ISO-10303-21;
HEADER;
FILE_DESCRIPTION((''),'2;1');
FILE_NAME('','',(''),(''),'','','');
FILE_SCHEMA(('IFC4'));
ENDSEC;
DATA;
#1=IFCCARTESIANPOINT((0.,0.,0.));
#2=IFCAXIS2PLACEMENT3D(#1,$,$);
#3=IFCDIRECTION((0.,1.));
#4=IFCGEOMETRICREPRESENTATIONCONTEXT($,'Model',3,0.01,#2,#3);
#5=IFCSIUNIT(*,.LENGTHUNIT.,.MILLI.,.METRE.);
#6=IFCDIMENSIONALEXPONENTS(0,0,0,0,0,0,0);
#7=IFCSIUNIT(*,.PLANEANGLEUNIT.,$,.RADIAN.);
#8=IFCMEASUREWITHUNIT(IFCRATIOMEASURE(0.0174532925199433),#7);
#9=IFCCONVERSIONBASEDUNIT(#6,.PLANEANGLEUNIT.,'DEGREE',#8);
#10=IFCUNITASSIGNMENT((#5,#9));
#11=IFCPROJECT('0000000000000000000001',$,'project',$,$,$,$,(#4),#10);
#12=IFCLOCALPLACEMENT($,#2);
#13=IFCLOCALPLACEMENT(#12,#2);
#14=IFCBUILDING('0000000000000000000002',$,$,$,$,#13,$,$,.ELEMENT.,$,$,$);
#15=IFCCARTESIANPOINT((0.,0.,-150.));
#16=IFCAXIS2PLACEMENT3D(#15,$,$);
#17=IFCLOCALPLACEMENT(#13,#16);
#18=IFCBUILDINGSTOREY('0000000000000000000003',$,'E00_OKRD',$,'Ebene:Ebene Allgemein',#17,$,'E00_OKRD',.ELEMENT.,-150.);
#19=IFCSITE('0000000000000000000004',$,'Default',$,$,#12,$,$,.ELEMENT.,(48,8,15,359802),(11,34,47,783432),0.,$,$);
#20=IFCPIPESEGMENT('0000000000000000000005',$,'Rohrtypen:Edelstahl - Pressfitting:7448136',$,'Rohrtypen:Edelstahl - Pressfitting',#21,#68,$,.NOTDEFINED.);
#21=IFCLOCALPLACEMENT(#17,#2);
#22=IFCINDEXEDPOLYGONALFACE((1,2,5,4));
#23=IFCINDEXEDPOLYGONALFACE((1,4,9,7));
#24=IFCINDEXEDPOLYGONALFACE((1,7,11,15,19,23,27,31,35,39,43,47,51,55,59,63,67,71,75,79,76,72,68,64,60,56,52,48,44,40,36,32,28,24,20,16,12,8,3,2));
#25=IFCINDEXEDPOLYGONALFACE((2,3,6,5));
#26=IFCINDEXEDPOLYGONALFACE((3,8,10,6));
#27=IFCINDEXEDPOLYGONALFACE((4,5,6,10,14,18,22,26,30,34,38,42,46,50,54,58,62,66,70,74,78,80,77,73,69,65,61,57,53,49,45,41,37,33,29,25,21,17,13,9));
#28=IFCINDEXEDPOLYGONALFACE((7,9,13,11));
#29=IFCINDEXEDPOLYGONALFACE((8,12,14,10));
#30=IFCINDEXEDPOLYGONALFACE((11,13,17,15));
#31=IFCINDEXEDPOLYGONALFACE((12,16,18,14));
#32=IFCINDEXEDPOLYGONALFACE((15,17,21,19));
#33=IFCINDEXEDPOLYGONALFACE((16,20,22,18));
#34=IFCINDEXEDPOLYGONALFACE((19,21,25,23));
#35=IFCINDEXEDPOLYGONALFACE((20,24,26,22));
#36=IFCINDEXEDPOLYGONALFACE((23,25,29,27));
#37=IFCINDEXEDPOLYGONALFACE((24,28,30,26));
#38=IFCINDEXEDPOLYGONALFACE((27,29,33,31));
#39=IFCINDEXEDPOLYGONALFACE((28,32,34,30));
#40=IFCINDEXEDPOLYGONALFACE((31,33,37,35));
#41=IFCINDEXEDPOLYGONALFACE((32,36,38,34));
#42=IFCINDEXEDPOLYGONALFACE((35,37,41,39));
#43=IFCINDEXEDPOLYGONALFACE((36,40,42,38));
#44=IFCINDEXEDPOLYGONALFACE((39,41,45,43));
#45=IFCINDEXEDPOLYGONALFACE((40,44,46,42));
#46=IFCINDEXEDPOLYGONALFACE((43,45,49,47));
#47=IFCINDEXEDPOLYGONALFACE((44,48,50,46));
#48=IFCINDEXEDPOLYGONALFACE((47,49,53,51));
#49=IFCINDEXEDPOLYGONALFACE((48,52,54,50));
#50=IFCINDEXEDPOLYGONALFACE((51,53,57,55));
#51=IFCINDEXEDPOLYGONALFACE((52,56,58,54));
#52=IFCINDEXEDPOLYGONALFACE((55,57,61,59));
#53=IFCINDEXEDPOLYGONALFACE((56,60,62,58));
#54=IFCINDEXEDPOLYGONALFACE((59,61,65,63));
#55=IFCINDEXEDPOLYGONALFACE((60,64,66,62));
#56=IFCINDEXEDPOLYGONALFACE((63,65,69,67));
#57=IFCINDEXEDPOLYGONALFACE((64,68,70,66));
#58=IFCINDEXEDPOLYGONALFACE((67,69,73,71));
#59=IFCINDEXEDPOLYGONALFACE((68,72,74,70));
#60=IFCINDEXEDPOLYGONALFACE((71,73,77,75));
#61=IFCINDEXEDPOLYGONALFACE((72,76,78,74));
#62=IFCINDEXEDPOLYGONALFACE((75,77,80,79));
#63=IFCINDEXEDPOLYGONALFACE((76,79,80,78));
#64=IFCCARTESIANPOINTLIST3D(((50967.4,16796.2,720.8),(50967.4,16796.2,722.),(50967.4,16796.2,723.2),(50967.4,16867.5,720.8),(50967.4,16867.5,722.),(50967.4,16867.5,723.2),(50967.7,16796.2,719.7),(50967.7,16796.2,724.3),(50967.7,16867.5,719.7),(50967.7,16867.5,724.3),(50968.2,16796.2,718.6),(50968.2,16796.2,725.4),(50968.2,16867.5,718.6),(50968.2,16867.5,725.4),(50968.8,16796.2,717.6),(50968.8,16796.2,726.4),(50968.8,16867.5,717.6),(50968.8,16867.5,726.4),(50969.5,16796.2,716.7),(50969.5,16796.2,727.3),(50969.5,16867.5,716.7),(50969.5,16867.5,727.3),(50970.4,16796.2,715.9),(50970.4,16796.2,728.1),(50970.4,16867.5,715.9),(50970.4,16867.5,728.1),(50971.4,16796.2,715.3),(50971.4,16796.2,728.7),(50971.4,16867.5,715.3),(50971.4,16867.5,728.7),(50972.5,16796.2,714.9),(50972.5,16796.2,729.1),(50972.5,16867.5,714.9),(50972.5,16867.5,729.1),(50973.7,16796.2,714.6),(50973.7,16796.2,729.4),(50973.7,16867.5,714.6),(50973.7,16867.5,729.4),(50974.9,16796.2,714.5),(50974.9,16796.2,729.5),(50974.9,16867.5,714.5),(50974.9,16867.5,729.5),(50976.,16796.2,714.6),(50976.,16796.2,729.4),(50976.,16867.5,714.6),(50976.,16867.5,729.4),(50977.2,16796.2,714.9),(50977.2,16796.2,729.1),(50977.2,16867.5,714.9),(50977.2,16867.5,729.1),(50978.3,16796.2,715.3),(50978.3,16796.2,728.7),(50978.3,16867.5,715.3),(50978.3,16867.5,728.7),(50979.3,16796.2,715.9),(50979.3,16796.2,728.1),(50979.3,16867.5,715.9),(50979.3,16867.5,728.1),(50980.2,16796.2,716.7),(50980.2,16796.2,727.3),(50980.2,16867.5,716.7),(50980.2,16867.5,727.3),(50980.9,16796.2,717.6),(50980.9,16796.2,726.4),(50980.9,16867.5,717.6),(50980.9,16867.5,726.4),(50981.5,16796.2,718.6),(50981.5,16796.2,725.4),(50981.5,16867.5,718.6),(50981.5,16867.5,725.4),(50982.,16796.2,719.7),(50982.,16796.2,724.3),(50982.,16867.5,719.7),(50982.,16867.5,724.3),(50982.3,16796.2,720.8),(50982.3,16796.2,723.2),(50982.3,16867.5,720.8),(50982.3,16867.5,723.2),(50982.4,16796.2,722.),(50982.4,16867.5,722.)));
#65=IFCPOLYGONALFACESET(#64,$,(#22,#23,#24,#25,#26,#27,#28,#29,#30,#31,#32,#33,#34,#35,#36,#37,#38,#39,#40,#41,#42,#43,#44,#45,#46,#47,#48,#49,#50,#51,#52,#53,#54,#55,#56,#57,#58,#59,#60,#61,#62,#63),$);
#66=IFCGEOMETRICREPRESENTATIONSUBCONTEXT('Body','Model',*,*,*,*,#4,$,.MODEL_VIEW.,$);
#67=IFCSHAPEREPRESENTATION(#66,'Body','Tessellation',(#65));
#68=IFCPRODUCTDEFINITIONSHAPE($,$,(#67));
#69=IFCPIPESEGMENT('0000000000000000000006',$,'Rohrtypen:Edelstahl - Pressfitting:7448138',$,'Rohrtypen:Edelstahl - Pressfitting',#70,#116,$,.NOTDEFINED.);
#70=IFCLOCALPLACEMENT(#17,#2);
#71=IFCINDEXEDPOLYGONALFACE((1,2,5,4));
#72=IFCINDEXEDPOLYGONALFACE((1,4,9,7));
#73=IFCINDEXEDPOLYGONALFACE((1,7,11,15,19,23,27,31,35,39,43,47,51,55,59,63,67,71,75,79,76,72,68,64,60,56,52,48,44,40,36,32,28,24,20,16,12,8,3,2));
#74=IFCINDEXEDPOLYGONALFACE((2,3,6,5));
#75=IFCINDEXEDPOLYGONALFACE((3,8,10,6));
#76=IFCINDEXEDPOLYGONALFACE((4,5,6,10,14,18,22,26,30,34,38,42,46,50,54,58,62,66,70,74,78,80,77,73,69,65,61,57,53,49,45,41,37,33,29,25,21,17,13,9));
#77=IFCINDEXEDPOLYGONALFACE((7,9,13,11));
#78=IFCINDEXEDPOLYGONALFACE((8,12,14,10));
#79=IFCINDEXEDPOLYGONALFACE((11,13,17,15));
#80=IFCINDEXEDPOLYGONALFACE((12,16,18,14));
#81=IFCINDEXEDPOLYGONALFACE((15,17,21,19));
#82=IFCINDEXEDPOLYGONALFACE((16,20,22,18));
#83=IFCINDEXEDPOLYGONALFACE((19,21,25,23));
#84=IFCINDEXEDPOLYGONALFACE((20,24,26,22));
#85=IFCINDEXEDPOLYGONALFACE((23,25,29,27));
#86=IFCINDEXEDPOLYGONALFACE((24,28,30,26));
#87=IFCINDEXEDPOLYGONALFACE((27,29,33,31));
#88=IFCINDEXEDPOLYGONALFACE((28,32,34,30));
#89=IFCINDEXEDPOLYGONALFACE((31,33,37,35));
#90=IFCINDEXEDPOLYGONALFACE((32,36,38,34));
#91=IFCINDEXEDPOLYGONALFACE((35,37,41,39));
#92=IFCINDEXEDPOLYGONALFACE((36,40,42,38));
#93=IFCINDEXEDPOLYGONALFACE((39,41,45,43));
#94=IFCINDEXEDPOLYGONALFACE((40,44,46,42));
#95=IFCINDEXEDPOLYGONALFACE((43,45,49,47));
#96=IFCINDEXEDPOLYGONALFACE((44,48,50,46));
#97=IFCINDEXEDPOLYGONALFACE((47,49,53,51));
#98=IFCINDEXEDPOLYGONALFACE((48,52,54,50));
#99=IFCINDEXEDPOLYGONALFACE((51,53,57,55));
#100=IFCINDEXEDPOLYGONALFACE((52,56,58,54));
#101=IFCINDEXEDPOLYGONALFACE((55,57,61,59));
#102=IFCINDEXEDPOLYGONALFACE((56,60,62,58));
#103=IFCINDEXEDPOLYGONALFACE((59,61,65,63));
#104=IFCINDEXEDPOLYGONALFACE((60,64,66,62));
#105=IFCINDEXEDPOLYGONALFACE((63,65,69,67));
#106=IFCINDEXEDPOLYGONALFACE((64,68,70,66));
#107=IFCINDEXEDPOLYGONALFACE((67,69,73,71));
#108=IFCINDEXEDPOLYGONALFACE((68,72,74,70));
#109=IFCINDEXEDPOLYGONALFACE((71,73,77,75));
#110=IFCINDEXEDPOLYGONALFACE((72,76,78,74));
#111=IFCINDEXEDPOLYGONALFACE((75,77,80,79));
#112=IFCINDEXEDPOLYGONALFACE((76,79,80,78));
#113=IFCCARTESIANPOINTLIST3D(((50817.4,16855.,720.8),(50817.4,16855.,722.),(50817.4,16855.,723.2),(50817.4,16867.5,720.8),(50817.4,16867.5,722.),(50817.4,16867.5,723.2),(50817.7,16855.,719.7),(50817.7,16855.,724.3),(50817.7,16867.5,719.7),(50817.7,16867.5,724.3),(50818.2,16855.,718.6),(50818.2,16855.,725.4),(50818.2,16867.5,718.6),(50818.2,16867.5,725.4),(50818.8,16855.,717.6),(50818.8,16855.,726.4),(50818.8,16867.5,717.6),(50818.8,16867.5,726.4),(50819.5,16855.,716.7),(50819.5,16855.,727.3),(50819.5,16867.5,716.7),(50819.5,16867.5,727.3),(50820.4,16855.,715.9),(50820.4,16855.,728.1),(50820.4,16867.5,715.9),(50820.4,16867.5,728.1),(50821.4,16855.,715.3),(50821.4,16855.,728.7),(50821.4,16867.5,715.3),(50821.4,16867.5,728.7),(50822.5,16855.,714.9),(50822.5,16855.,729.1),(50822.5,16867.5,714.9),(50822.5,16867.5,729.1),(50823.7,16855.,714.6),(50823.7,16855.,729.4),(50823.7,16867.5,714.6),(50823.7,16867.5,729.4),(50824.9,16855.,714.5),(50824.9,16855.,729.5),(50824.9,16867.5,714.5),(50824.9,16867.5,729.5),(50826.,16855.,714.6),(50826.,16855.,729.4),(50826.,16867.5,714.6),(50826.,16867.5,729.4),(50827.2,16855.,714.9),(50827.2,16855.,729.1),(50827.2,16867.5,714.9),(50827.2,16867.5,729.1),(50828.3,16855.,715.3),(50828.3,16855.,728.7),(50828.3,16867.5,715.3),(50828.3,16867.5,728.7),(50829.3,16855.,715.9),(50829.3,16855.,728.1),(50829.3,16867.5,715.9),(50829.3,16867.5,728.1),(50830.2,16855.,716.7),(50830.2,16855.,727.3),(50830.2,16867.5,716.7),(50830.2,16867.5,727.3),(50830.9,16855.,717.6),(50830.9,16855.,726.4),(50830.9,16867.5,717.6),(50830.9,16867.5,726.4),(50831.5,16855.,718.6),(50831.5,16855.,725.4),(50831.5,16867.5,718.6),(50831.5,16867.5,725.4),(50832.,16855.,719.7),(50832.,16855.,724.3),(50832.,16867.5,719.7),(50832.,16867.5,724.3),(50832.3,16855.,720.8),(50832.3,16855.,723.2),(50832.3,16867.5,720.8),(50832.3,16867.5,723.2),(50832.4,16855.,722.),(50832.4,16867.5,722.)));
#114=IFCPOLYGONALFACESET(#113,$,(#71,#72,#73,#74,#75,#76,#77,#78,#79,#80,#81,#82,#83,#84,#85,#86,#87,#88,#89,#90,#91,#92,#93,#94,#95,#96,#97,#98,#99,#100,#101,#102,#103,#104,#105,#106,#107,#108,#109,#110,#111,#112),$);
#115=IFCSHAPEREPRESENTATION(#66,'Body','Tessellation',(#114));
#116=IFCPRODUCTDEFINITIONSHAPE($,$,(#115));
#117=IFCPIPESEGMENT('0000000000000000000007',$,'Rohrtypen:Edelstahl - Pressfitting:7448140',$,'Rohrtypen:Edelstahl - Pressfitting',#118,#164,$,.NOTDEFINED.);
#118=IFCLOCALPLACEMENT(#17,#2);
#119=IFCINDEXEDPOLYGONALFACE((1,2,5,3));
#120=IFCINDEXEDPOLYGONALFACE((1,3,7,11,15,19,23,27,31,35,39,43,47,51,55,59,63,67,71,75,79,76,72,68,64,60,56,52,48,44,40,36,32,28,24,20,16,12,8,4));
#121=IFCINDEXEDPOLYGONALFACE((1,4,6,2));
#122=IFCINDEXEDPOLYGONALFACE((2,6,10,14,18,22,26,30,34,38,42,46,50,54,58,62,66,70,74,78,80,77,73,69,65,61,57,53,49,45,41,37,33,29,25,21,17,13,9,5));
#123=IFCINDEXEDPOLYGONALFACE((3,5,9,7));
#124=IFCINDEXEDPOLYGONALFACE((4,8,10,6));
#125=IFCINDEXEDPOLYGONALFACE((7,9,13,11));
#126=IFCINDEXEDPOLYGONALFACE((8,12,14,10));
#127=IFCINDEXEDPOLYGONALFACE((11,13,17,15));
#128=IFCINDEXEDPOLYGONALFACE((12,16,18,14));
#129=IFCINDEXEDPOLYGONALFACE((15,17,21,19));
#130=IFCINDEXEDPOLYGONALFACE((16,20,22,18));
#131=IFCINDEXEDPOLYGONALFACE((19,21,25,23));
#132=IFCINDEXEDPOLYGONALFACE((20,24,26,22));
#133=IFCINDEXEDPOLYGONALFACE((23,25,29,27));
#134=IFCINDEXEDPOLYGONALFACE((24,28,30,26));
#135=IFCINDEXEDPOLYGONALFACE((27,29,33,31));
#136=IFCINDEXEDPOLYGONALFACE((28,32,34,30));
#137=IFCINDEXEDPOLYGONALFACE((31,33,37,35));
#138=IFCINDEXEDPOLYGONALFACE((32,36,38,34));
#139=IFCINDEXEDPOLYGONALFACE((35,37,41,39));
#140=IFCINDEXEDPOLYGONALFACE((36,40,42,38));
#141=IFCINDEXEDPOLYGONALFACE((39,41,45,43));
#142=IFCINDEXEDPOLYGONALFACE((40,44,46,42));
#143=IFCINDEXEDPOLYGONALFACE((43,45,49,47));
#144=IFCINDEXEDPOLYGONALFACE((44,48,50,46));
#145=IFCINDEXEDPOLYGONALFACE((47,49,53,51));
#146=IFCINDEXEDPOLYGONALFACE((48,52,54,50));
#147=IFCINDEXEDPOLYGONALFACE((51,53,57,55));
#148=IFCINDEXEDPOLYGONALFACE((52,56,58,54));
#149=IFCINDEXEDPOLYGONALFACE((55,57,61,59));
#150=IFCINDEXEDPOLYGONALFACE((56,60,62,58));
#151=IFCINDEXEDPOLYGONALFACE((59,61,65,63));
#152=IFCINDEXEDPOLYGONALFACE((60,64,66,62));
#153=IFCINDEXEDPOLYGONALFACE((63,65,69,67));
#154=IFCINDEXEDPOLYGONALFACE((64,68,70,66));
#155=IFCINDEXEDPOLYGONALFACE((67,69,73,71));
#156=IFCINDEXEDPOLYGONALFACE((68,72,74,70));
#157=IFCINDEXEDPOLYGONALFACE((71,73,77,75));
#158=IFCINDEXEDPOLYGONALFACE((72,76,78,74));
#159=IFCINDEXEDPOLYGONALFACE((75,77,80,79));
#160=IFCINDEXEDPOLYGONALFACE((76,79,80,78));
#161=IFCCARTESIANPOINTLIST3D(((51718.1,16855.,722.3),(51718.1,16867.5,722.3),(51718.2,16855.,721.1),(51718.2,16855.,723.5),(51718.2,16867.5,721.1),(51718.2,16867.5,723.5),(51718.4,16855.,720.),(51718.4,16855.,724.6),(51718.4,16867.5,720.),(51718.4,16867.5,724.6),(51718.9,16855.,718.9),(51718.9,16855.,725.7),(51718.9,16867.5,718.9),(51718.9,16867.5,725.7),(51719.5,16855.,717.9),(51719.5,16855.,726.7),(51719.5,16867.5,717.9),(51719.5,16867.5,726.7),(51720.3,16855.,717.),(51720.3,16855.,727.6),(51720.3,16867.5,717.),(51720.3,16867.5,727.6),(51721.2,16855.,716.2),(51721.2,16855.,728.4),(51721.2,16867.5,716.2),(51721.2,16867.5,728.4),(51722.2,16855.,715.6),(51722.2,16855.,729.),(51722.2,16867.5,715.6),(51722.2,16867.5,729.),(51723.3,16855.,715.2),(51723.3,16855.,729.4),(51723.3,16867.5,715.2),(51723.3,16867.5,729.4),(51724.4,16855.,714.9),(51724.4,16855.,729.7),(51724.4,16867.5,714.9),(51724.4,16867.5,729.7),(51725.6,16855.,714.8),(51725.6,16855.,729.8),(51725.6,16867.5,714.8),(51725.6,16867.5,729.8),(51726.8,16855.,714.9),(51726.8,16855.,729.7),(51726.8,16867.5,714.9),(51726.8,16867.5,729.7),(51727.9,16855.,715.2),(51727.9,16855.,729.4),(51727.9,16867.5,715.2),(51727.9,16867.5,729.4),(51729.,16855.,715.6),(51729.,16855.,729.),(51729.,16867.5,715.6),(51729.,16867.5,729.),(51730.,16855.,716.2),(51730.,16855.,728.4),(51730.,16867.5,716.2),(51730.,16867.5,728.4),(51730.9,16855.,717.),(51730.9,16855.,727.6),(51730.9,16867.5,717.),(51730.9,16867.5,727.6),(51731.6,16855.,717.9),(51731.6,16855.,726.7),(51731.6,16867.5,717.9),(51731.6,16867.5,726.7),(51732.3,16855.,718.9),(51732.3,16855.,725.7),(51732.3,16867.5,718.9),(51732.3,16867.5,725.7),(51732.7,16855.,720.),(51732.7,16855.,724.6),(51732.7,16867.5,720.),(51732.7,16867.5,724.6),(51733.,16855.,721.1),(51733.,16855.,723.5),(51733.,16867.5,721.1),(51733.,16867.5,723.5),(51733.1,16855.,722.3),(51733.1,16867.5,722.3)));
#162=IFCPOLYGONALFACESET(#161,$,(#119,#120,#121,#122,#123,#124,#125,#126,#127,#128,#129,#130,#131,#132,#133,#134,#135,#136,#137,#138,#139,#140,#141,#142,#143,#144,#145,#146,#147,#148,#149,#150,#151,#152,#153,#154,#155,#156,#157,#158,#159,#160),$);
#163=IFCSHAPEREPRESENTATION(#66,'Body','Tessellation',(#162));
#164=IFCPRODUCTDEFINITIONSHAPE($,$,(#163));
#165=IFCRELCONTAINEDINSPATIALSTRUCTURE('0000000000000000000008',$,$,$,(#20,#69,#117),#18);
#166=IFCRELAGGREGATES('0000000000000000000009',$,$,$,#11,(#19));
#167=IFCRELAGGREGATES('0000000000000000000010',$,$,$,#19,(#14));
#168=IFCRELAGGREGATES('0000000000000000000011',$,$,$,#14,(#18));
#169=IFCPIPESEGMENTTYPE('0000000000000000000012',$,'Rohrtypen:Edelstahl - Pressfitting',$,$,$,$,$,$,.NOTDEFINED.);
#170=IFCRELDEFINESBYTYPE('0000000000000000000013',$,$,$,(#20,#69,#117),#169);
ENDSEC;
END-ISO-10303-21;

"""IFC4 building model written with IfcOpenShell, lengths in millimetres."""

from ifc_helpers import new_model, entity, si_unit, converted_unit, direction, frame, origin, place, context, subcontext, project, spatial, indexed_curve, outline, extrude, type_object, element, save


model = new_model("IFC4")

# Units and contexts
model_context = context("Model", 3, precision=0.01, world=origin(), true_north=direction((0.0, 1.0)))
body_context = subcontext(model_context, "Body", "Model", "MODEL_VIEW")
ifc_project = project(units=[si_unit("LENGTHUNIT", "METRE", prefix="MILLI"), converted_unit("PLANEANGLEUNIT", "DEGREE", entity("IfcRatioMeasure", 0.0174532925199433), si_unit("PLANEANGLEUNIT", "RADIAN"), dimensions=[0, 0, 0, 0, 0, 0, 0])], contexts=[model_context])

# Site, building, storey
site_placement = place(None, origin())
site = spatial("IfcSite", under=ifc_project, at=site_placement, Name="Default", CompositionType="ELEMENT", RefLatitude=(48, 8, 15, 359802), RefLongitude=(11, 34, 47, 783432), RefElevation=0.0)
building_placement = place(site_placement, origin())
building = spatial("IfcBuilding", under=site, at=building_placement, CompositionType="ELEMENT")
storey_placement = place(building_placement, frame((0.0, 0.0, -150.0)))
storey = spatial("IfcBuildingStorey", under=building, at=storey_placement, Name="E00_OKRD", ObjectType="Ebene:Ebene Allgemein", LongName="E00_OKRD", CompositionType="ELEMENT", Elevation=-150.0)

# Pipe segments
pipe_segment_type_1 = type_object("IfcPipeSegmentType", Name="Rohrtypen:Edelstahl - Pressfitting", PredefinedType="NOTDEFINED")
pipe_segment_1_placement = place(storey_placement, origin())
element("IfcPipeSegment", 1, at=pipe_segment_1_placement, inside=storey, type_object=pipe_segment_type_1, Name="Rohrtypen:Edelstahl - Pressfitting:7448136", ObjectType="Rohrtypen:Edelstahl - Pressfitting", PredefinedType="NOTDEFINED", context=body_context, shape_type="SweptSolid", body=[
    extrude(outline(indexed_curve([(7.5, 0.0), (7.4, 1.2), (7.1, 2.3), (6.7, 3.4), (6.1, 4.4), (5.3, 5.3), (4.4, 6.1), (3.4, 6.7), (2.3, 7.1), (1.2, 7.4), (0.0, 7.5), (-1.2, 7.4), (-2.3, 7.1), (-3.4, 6.7), (-4.4, 6.1), (-5.3, 5.3), (-6.1, 4.4), (-6.7, 3.4), (-7.1, 2.3), (-7.4, 1.2), (-7.5, 0.0), (-7.4, -1.2), (-7.1, -2.3), (-6.7, -3.4), (-6.1, -4.4), (-5.3, -5.3), (-4.4, -6.1), (-3.4, -6.7), (-2.3, -7.1), (-1.2, -7.4), (0.0, -7.5), (1.2, -7.4), (2.3, -7.1), (3.4, -6.7), (4.4, -6.1), (5.3, -5.3), (6.1, -4.4), (6.7, -3.4), (7.1, -2.3), (7.4, -1.2), (7.5, 0.0)], self_intersect=False)), frame((50974.9, 16796.2, 722.0), z_axis=(0.000006, 1.0, 0.0), x_axis=(-1.0, 0.000006, 0.0)), (0.0, 0.0, 1.0), 71.3),
])
pipe_segment_2_placement = place(storey_placement, origin())
element("IfcPipeSegment", 2, at=pipe_segment_2_placement, inside=storey, type_object=pipe_segment_type_1, Name="Rohrtypen:Edelstahl - Pressfitting:7448138", ObjectType="Rohrtypen:Edelstahl - Pressfitting", PredefinedType="NOTDEFINED", context=body_context, shape_type="SweptSolid", body=[
    extrude(outline(indexed_curve([(7.5, 0.0), (7.4, 1.2), (7.1, 2.3), (6.7, 3.4), (6.1, 4.4), (5.3, 5.3), (4.4, 6.1), (3.4, 6.7), (2.3, 7.1), (1.2, 7.4), (0.0, 7.5), (-1.2, 7.4), (-2.3, 7.1), (-3.4, 6.7), (-4.4, 6.1), (-5.3, 5.3), (-6.1, 4.4), (-6.7, 3.4), (-7.1, 2.3), (-7.4, 1.2), (-7.5, 0.0), (-7.4, -1.2), (-7.1, -2.3), (-6.7, -3.4), (-6.1, -4.4), (-5.3, -5.3), (-4.4, -6.1), (-3.4, -6.7), (-2.3, -7.1), (-1.2, -7.4), (0.0, -7.5), (1.2, -7.4), (2.3, -7.1), (3.4, -6.7), (4.4, -6.1), (5.3, -5.3), (6.1, -4.4), (6.7, -3.4), (7.1, -2.3), (7.4, -1.2), (7.5, 0.0)], self_intersect=False)), frame((50824.9, 16855.0, 722.0), z_axis=(0.0, 1.0, 0.0), x_axis=(-1.0, 0.0, 0.0)), (0.0, 0.0, 1.0), 12.6),
])
pipe_segment_3_placement = place(storey_placement, origin())
element("IfcPipeSegment", 3, at=pipe_segment_3_placement, inside=storey, type_object=pipe_segment_type_1, Name="Rohrtypen:Edelstahl - Pressfitting:7448140", ObjectType="Rohrtypen:Edelstahl - Pressfitting", PredefinedType="NOTDEFINED", context=body_context, shape_type="SweptSolid", body=[
    extrude(outline(indexed_curve([(7.5, 0.0), (7.4, 1.2), (7.1, 2.3), (6.7, 3.4), (6.1, 4.4), (5.3, 5.3), (4.4, 6.1), (3.4, 6.7), (2.3, 7.1), (1.2, 7.4), (0.0, 7.5), (-1.2, 7.4), (-2.3, 7.1), (-3.4, 6.7), (-4.4, 6.1), (-5.3, 5.3), (-6.1, 4.4), (-6.7, 3.4), (-7.1, 2.3), (-7.4, 1.2), (-7.5, 0.0), (-7.4, -1.2), (-7.1, -2.3), (-6.7, -3.4), (-6.1, -4.4), (-5.3, -5.3), (-4.4, -6.1), (-3.4, -6.7), (-2.3, -7.1), (-1.2, -7.4), (0.0, -7.5), (1.2, -7.4), (2.3, -7.1), (3.4, -6.7), (4.4, -6.1), (5.3, -5.3), (6.1, -4.4), (6.7, -3.4), (7.1, -2.3), (7.4, -1.2), (7.5, 0.0)], self_intersect=False)), frame((51725.6, 16855.0, 722.3), z_axis=(0.0, 1.0, 0.0), x_axis=(-1.0, 0.0, 0.0)), (0.0, 0.0, 1.0), 12.6),
])

save(model, "model.ifc")
